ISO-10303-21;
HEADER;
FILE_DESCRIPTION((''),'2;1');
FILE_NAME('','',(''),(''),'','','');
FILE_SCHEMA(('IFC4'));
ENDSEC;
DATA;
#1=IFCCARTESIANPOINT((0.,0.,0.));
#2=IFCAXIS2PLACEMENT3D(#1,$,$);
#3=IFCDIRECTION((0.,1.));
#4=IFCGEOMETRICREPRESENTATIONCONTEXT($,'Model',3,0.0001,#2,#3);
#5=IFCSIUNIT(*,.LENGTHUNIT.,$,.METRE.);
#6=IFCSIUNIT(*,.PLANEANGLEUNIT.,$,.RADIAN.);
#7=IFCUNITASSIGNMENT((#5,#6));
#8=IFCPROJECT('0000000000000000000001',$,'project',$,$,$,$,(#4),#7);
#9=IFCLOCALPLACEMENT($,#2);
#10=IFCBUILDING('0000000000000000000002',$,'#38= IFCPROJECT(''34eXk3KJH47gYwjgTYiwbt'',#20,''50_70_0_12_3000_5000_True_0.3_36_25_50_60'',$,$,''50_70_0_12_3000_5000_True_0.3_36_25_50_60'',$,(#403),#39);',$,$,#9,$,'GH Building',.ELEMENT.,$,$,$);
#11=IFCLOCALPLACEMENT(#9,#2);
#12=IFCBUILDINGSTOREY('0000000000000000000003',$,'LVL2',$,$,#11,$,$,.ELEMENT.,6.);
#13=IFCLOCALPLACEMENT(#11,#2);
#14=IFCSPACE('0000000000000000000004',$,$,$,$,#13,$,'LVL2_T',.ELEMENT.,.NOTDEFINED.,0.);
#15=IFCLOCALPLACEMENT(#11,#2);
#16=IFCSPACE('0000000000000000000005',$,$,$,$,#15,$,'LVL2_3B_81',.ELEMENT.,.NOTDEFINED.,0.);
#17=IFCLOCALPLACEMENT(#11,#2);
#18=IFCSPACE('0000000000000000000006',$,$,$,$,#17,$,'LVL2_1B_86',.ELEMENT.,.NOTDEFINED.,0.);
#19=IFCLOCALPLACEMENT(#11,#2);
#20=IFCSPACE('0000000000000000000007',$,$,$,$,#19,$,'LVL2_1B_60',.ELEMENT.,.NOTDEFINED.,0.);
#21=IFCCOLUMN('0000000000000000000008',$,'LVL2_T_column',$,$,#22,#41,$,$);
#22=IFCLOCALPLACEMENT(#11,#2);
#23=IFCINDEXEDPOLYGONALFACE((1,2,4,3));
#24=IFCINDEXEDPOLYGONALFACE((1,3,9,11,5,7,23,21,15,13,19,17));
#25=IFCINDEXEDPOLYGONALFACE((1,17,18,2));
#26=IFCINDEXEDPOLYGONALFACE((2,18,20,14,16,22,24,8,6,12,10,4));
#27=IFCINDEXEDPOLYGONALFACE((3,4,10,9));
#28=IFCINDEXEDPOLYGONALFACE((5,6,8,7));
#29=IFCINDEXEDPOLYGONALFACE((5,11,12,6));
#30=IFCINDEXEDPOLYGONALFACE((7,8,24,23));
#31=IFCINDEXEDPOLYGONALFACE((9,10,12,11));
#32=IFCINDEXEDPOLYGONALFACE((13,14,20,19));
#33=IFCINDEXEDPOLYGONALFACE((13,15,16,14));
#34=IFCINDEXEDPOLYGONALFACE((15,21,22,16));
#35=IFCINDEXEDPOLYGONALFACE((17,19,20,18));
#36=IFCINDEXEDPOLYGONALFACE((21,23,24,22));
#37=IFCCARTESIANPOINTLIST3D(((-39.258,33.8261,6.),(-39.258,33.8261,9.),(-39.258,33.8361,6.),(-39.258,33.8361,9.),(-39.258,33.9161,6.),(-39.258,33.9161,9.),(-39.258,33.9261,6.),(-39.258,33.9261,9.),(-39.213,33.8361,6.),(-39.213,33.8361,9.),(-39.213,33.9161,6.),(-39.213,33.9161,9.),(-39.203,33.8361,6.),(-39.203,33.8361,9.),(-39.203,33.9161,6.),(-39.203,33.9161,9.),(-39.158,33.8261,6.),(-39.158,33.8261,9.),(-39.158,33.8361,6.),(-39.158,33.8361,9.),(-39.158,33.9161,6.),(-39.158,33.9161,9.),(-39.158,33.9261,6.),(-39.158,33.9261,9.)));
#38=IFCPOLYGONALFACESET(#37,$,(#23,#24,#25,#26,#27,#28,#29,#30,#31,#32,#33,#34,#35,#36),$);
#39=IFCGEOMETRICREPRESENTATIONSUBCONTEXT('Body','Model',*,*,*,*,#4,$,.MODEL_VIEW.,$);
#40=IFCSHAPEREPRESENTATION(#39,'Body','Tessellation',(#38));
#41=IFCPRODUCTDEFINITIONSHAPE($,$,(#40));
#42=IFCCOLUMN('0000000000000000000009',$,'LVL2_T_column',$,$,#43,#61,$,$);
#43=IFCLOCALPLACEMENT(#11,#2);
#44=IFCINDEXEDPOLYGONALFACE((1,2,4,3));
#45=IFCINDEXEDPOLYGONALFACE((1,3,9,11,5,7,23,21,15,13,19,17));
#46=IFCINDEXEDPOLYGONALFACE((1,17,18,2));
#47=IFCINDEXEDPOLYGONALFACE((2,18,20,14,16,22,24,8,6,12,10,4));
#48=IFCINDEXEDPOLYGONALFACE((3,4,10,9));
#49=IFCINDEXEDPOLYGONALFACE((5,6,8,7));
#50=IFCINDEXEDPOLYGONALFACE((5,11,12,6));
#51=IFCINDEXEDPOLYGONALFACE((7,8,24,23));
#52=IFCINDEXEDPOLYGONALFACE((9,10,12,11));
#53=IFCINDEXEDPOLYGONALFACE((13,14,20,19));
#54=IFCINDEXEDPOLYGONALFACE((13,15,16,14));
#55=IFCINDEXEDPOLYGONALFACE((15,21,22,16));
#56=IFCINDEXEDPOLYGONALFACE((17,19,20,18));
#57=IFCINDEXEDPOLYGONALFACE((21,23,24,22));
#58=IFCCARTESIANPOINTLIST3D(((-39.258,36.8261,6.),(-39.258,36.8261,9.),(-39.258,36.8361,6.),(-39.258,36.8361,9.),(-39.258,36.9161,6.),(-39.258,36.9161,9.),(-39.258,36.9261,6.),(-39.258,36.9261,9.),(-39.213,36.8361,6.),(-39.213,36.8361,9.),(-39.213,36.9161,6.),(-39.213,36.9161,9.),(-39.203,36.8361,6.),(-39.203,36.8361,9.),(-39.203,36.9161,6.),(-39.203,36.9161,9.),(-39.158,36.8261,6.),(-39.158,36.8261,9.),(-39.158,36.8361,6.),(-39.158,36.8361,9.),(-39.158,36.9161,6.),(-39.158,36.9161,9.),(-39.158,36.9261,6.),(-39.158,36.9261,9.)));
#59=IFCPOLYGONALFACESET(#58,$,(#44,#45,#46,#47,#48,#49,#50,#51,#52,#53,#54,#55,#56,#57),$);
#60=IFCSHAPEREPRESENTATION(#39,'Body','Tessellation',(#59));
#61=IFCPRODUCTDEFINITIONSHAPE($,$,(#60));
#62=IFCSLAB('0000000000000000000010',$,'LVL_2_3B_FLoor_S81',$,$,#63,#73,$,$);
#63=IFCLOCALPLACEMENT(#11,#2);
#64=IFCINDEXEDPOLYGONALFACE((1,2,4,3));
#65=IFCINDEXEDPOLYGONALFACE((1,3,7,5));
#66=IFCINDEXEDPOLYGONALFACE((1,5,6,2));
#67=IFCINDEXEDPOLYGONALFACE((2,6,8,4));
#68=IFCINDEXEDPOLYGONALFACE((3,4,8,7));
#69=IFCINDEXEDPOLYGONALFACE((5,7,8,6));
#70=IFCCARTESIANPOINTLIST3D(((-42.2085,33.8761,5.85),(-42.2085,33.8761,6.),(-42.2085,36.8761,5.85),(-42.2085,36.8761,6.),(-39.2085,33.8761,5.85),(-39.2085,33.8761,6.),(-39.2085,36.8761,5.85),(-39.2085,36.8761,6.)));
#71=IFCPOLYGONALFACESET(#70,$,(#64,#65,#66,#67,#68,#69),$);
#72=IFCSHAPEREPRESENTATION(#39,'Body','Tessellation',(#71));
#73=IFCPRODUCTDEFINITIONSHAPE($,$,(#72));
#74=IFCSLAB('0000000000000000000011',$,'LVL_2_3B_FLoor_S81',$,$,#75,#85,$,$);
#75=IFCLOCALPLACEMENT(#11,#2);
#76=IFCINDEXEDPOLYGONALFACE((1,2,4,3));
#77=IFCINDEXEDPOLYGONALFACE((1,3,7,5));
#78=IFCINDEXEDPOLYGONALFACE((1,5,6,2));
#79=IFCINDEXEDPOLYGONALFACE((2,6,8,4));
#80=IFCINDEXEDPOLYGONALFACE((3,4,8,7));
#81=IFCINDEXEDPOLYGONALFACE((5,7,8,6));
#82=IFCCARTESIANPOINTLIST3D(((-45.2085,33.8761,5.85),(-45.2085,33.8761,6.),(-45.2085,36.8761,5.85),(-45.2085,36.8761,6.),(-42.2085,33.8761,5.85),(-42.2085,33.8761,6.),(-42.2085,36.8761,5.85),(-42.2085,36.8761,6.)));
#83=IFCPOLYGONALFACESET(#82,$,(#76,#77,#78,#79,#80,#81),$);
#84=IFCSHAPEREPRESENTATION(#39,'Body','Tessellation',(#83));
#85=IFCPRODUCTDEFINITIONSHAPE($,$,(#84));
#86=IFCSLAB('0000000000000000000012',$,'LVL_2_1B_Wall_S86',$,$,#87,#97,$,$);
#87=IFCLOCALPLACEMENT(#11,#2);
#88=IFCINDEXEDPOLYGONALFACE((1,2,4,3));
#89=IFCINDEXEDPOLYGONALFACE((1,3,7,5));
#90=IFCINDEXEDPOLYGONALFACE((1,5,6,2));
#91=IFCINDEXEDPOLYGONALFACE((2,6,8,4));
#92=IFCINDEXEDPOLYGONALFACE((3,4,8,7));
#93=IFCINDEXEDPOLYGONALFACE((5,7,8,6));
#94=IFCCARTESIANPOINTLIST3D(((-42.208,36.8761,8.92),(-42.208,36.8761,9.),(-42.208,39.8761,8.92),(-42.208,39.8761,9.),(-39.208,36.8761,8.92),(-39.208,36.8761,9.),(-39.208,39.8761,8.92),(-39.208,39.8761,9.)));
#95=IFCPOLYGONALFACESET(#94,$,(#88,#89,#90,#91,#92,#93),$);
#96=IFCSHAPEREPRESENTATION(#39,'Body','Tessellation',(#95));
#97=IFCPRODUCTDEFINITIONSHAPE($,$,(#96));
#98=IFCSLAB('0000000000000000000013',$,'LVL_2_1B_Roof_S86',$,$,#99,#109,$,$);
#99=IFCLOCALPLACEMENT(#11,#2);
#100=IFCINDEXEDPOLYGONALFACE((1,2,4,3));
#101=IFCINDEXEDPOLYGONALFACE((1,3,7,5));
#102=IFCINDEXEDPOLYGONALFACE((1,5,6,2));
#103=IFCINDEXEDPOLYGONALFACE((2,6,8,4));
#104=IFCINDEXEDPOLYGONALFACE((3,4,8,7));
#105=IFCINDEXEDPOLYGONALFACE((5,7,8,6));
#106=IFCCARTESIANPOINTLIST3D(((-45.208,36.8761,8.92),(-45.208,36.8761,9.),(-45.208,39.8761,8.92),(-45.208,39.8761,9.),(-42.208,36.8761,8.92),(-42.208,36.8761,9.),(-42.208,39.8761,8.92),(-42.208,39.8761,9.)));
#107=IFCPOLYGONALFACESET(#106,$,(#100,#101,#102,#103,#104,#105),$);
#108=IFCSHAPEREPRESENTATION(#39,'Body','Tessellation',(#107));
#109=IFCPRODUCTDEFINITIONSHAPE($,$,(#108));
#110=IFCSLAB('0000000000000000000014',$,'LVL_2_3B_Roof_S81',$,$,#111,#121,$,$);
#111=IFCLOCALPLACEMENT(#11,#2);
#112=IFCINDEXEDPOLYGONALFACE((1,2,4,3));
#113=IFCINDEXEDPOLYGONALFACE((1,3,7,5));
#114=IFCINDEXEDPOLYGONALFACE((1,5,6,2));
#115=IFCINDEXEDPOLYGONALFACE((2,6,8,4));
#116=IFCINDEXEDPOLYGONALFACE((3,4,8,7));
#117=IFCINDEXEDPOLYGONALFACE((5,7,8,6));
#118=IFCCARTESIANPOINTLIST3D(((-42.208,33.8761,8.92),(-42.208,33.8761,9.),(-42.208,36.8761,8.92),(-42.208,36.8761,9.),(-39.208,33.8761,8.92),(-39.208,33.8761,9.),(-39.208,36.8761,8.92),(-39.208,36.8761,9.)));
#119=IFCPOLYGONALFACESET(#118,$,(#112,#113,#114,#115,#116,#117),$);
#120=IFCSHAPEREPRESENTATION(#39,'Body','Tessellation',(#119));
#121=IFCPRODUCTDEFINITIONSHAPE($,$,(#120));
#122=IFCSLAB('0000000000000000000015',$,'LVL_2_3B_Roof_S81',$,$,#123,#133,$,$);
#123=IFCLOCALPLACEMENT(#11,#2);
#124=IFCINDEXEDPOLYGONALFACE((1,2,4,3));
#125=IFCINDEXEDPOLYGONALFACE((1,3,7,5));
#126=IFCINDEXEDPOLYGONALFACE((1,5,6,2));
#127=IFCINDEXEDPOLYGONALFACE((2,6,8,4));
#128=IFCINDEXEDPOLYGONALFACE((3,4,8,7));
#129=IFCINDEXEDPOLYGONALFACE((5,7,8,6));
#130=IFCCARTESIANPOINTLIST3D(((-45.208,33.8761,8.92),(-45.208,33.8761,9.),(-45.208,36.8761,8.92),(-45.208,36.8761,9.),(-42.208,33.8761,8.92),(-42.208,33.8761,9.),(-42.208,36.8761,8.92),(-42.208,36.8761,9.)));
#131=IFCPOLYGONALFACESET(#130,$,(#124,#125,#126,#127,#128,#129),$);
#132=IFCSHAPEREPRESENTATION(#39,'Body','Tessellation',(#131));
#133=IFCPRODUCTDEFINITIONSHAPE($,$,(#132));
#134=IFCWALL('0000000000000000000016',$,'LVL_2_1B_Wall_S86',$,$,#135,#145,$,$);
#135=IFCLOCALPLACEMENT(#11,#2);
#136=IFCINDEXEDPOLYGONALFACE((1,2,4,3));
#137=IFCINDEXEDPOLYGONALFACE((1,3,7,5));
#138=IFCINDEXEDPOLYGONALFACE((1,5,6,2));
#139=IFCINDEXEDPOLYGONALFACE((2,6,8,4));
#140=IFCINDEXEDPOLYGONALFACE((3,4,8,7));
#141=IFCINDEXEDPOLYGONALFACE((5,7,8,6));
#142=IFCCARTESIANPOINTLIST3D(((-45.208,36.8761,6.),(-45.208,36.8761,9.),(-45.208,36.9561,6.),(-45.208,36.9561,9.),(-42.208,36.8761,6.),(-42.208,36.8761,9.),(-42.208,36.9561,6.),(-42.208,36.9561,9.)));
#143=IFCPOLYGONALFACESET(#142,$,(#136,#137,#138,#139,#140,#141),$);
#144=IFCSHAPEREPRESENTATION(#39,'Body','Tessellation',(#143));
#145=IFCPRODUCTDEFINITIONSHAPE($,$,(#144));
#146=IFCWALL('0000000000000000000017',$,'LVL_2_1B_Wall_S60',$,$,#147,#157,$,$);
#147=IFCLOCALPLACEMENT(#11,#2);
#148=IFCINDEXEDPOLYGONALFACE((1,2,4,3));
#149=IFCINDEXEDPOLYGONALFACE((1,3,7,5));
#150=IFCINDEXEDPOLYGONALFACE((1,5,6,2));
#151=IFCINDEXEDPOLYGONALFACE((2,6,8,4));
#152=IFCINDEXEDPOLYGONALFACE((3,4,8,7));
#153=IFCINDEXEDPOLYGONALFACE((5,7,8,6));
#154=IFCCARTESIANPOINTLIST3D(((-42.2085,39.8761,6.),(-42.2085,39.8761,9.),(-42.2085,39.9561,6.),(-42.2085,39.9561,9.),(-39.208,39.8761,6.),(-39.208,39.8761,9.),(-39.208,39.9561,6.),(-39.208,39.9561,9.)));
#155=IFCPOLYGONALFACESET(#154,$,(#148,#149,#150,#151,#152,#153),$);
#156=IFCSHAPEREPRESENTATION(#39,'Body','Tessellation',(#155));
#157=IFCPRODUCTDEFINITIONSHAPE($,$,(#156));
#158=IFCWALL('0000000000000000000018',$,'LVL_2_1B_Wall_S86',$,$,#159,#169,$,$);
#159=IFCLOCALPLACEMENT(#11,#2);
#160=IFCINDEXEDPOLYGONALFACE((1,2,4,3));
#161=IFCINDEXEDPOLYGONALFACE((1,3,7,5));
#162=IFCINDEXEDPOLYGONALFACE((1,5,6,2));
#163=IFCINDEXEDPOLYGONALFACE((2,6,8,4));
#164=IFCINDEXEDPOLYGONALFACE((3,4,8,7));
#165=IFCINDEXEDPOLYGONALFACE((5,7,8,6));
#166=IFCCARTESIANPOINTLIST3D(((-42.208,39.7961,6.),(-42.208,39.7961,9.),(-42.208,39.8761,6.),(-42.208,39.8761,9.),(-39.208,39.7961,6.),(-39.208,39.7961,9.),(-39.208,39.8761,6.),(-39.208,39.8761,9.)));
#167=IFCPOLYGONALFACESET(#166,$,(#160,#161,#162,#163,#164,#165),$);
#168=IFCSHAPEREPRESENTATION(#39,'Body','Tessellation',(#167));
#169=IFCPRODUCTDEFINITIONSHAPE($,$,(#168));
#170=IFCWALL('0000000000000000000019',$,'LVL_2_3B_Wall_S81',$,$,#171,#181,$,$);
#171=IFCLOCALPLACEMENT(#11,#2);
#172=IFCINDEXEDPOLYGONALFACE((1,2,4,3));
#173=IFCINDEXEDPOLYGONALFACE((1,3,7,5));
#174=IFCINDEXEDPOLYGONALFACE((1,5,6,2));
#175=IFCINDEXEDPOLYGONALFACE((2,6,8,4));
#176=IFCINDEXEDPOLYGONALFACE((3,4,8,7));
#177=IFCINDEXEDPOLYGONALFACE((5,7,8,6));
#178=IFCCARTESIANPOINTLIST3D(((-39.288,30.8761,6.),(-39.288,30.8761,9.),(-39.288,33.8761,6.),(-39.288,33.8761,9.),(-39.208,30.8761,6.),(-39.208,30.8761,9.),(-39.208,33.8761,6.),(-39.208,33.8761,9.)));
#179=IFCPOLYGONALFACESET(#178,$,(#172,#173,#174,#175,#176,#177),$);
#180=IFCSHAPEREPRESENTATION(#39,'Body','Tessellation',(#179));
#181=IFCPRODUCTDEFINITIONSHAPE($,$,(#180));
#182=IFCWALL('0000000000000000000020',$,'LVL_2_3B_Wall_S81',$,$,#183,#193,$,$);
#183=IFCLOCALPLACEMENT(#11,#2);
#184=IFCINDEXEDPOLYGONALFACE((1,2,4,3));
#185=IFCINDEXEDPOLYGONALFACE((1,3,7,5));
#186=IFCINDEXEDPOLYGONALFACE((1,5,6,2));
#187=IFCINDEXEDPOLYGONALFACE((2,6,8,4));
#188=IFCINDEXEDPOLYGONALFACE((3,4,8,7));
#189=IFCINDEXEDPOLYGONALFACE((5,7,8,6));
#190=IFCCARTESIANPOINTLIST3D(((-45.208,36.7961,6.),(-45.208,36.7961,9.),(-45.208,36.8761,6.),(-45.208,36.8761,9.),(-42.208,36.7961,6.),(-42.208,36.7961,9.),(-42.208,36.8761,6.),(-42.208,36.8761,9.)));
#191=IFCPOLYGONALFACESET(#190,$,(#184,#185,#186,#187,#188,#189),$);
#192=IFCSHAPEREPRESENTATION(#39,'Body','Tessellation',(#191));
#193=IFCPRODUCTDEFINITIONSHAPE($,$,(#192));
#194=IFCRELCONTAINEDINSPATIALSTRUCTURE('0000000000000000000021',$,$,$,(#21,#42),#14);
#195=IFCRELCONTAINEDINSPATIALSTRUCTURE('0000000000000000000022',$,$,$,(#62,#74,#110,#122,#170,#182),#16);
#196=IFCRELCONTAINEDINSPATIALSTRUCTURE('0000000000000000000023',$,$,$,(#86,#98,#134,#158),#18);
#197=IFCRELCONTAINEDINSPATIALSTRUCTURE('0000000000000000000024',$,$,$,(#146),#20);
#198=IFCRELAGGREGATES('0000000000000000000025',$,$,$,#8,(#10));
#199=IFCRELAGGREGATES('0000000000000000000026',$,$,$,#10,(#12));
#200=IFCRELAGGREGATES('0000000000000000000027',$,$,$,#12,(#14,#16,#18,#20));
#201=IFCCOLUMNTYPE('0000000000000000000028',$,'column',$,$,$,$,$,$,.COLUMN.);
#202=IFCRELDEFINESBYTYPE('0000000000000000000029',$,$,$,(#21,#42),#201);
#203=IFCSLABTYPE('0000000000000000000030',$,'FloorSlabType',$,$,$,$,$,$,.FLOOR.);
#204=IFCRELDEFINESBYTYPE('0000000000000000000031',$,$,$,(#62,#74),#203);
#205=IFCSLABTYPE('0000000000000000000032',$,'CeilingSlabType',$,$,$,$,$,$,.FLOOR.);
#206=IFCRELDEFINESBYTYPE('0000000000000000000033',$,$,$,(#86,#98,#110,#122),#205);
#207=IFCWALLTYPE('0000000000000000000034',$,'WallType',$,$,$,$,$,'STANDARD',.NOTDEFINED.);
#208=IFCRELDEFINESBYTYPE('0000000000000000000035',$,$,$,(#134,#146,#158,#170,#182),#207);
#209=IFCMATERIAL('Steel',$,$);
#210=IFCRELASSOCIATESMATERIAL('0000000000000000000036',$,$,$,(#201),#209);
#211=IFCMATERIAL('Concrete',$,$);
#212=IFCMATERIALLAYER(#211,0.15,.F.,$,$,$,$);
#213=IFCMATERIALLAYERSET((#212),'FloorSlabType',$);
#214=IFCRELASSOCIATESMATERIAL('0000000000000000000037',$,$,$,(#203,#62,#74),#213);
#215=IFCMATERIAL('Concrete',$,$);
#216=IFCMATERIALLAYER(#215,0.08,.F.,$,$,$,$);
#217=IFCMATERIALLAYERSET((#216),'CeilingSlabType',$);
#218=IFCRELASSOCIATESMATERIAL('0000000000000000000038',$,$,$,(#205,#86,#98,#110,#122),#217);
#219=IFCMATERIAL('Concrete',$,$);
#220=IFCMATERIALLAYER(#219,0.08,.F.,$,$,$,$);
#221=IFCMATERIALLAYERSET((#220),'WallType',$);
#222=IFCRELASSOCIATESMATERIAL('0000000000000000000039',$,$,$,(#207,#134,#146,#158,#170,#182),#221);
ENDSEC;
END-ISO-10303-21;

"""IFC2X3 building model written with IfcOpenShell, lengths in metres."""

from ifc_helpers import new_model, si_unit, direction, frame, frame_2d, origin, origin_2d, place, context, subcontext, project, spatial, rectangle, i_section, extrude, material, layer, layer_set, layer_usage, type_object, element, save


model = new_model("IFC2X3")

# Units and contexts
model_context = context("Model", 3, precision=0.0001, world=origin(), true_north=direction((0.0, 1.0)))
body_context = subcontext(model_context, "Body", "Model", "MODEL_VIEW")
ifc_project = project(units=[si_unit("LENGTHUNIT", "METRE"), si_unit("PLANEANGLEUNIT", "RADIAN")], contexts=[model_context])

# Building, storey, space
building_placement = place(None, origin())
building = spatial("IfcBuilding", under=ifc_project, at=building_placement, Name="#38= IFCPROJECT('34eXk3KJH47gYwjgTYiwbt',#20,'50_70_0_12_3000_5000_True_0.3_36_25_50_60',$,$,'50_70_0_12_3000_5000_True_0.3_36_25_50_60',$,(#403),#39);", LongName="GH Building", CompositionType="ELEMENT")
storey_placement = place(building_placement, origin())
storey = spatial("IfcBuildingStorey", under=building, at=storey_placement, Name="LVL2", CompositionType="ELEMENT", Elevation=6.0)
space_1_placement = place(storey_placement, origin())
space_1 = spatial("IfcSpace", under=storey, at=space_1_placement, LongName="LVL2_T", CompositionType="ELEMENT", InteriorOrExteriorSpace="NOTDEFINED", ElevationWithFlooring=0.0)

# Columns
ifc_material_1 = material(Name="Steel")
column_type = type_object("IfcColumnType", Name="column", PredefinedType="COLUMN", material=ifc_material_1)
for number, where, name in (
    (1, (-39.208, 33.8761, 6.0), "LVL2_T_column"),
    (2, (-39.208, 36.8761, 6.0), "LVL2_T_column"),
):
    element("IfcColumn", number, at=place(space_1_placement, frame(where)), inside=space_1, type_object=column_type, Name=name, context=body_context, shape_type="SweptSolid", body=[
        extrude(i_section(OverallWidth=0.1, OverallDepth=0.1, WebThickness=0.01, FlangeThickness=0.01, at=origin_2d()), origin(), (0.0, 0.0, 1.0), 3.0),
    ])

# Shared definitions
space_2_placement = place(storey_placement, origin())
space_2 = spatial("IfcSpace", under=storey, at=space_2_placement, LongName="LVL2_3B_81", CompositionType="ELEMENT", InteriorOrExteriorSpace="NOTDEFINED", ElevationWithFlooring=0.0)

# Slabs
ifc_material_2 = material(Name="Concrete")
ifc_layer_1 = layer(ifc_material_2, 0.15, ventilated=False)
ifc_layer_set_1 = layer_set([ifc_layer_1], Name="FloorSlabType")
ifc_layer_usage_1 = layer_usage(ifc_layer_set_1, "AXIS3", "NEGATIVE", -0.15)
slab_type_1 = type_object("IfcSlabType", Name="FloorSlabType", PredefinedType="FLOOR", material=ifc_layer_set_1)
slab_1_placement = place(space_2_placement, frame((-42.2085, 36.8761, 5.85), z_axis=(0.0, 0.0, 1.0), x_axis=(0.0, -1.0, 0.0)))
element("IfcSlab", 3, at=slab_1_placement, inside=space_2, type_object=slab_type_1, material=ifc_layer_usage_1, Name="LVL_2_3B_FLoor_S81", context=body_context, shape_type="SweptSolid", body=[
    extrude(rectangle(XDim=3.0, YDim=3.0, at=frame_2d((1.5, 1.5))), origin(), (0.0, 0.0, 1.0), 0.15),
])
ifc_layer_usage_2 = layer_usage(ifc_layer_set_1, "AXIS3", "NEGATIVE", -0.15)
slab_2_placement = place(space_2_placement, frame((-45.2085, 36.8761, 5.85), z_axis=(0.0, 0.0, 1.0), x_axis=(0.0, -1.0, 0.0)))
element("IfcSlab", 4, at=slab_2_placement, inside=space_2, type_object=slab_type_1, material=ifc_layer_usage_2, Name="LVL_2_3B_FLoor_S81", context=body_context, shape_type="SweptSolid", body=[
    extrude(rectangle(XDim=3.0, YDim=3.0, at=frame_2d((1.5, 1.5))), origin(), (0.0, 0.0, 1.0), 0.15),
])

# Shared definitions
space_3_placement = place(storey_placement, origin())
space_3 = spatial("IfcSpace", under=storey, at=space_3_placement, LongName="LVL2_1B_86", CompositionType="ELEMENT", InteriorOrExteriorSpace="NOTDEFINED", ElevationWithFlooring=0.0)

# Slabs
ifc_material_3 = material(Name="Concrete")
ifc_layer_2 = layer(ifc_material_3, 0.08, ventilated=False)
ifc_layer_set_2 = layer_set([ifc_layer_2], Name="CeilingSlabType")
ifc_layer_usage_3 = layer_usage(ifc_layer_set_2, "AXIS3", "NEGATIVE", -0.08)
slab_type_2 = type_object("IfcSlabType", Name="CeilingSlabType", PredefinedType="FLOOR", material=ifc_layer_set_2)
slab_3_placement = place(space_3_placement, frame((-39.208, 39.8761, 8.92), z_axis=(0.0, 0.0, 1.0), x_axis=(-1.0, 0.0, 0.0)))
element("IfcSlab", 5, at=slab_3_placement, inside=space_3, type_object=slab_type_2, material=ifc_layer_usage_3, Name="LVL_2_1B_Wall_S86", context=body_context, shape_type="SweptSolid", body=[
    extrude(rectangle(XDim=3.0, YDim=3.0, at=frame_2d((1.5, 1.5))), origin(), (0.0, 0.0, 1.0), 0.08),
])
ifc_layer_usage_4 = layer_usage(ifc_layer_set_2, "AXIS3", "NEGATIVE", -0.08)
slab_4_placement = place(space_3_placement, frame((-42.208, 39.8761, 8.92), z_axis=(0.0, 0.0, 1.0), x_axis=(-1.0, 0.0, 0.0)))
element("IfcSlab", 6, at=slab_4_placement, inside=space_3, type_object=slab_type_2, material=ifc_layer_usage_4, Name="LVL_2_1B_Roof_S86", context=body_context, shape_type="SweptSolid", body=[
    extrude(rectangle(XDim=3.0, YDim=3.0, at=frame_2d((1.5, 1.5))), origin(), (0.0, 0.0, 1.0), 0.08),
])
ifc_layer_usage_5 = layer_usage(ifc_layer_set_2, "AXIS3", "NEGATIVE", -0.08)
slab_5_placement = place(space_2_placement, frame((-42.208, 36.8761, 8.92), z_axis=(0.0, 0.0, 1.0), x_axis=(0.0, -1.0, 0.0)))
element("IfcSlab", 7, at=slab_5_placement, inside=space_2, type_object=slab_type_2, material=ifc_layer_usage_5, Name="LVL_2_3B_Roof_S81", context=body_context, shape_type="SweptSolid", body=[
    extrude(rectangle(XDim=3.0, YDim=3.0, at=frame_2d((1.5, 1.5))), origin(), (0.0, 0.0, 1.0), 0.08),
])
ifc_layer_usage_6 = layer_usage(ifc_layer_set_2, "AXIS3", "NEGATIVE", -0.08)
slab_6_placement = place(space_2_placement, frame((-45.208, 36.8761, 8.92), z_axis=(0.0, 0.0, 1.0), x_axis=(0.0, -1.0, 0.0)))
element("IfcSlab", 8, at=slab_6_placement, inside=space_2, type_object=slab_type_2, material=ifc_layer_usage_6, Name="LVL_2_3B_Roof_S81", context=body_context, shape_type="SweptSolid", body=[
    extrude(rectangle(XDim=3.0, YDim=3.0, at=frame_2d((1.5, 1.5))), origin(), (0.0, 0.0, 1.0), 0.08),
])

# Shared definitions
ifc_material_4 = material(Name="Concrete")
ifc_layer_3 = layer(ifc_material_4, 0.08, ventilated=False)
ifc_layer_set_3 = layer_set([ifc_layer_3], Name="WallType")
wall_type = type_object("IfcWallType", Name="WallType", ElementType="STANDARD", PredefinedType="NOTDEFINED", material=ifc_layer_set_3)

# Shared definitions
space_4_placement = place(storey_placement, origin())
space_4 = spatial("IfcSpace", under=storey, at=space_4_placement, LongName="LVL2_1B_60", CompositionType="ELEMENT", InteriorOrExteriorSpace="NOTDEFINED", ElevationWithFlooring=0.0)

# Walls
ifc_layer_usage_7 = layer_usage(ifc_layer_set_3, "AXIS2", "NEGATIVE", 0.0)
wall_1_placement = place(space_3_placement, frame((-42.208, 36.8761, 6.0), z_axis=(0.0, 0.0, 1.0), x_axis=(-1.0, 0.0, 0.0)))
element("IfcWall", 9, at=wall_1_placement, inside=space_3, type_object=wall_type, material=ifc_layer_usage_7, Name="LVL_2_1B_Wall_S86", context=body_context, shape_type="SweptSolid", body=[
    extrude(rectangle(XDim=3.0, YDim=0.08, at=frame_2d((1.5, -0.04))), origin(), (0.0, 0.0, 1.0), 3.0),
])
ifc_layer_usage_8 = layer_usage(ifc_layer_set_3, "AXIS2", "NEGATIVE", 0.0)
wall_2_placement = place(space_4_placement, frame((-39.208, 39.8761, 6.0), z_axis=(0.0, 0.0, 1.0), x_axis=(-1.0, 0.0, 0.0)))
element("IfcWall", 10, at=wall_2_placement, inside=space_4, type_object=wall_type, material=ifc_layer_usage_8, Name="LVL_2_1B_Wall_S60", context=body_context, shape_type="SweptSolid", body=[
    extrude(rectangle(XDim=3.0005, YDim=0.08, at=frame_2d((1.5003, -0.04))), origin(), (0.0, 0.0, 1.0), 3.0),
])
ifc_layer_usage_9 = layer_usage(ifc_layer_set_3, "AXIS2", "NEGATIVE", 0.0)
wall_3_placement = place(space_3_placement, frame((-42.208, 39.8761, 6.0)))
element("IfcWall", 11, at=wall_3_placement, inside=space_3, type_object=wall_type, material=ifc_layer_usage_9, Name="LVL_2_1B_Wall_S86", context=body_context, shape_type="SweptSolid", body=[
    extrude(rectangle(XDim=3.0, YDim=0.08, at=frame_2d((1.5, -0.04))), origin(), (0.0, 0.0, 1.0), 3.0),
])

# Walls
ifc_layer_usage_10 = layer_usage(ifc_layer_set_3, "AXIS2", "NEGATIVE", 0.0)
wall_4_placement = place(space_2_placement, frame((-39.208, 33.8761, 6.0), z_axis=(0.0, 0.0, 1.0), x_axis=(0.0, -1.0, 0.0)))
element("IfcWall", 12, at=wall_4_placement, inside=space_2, type_object=wall_type, material=ifc_layer_usage_10, Name="LVL_2_3B_Wall_S81", context=body_context, shape_type="SweptSolid", body=[
    extrude(rectangle(XDim=3.0, YDim=0.08, at=frame_2d((1.5, -0.04))), origin(), (0.0, 0.0, 1.0), 3.0),
])
ifc_layer_usage_11 = layer_usage(ifc_layer_set_3, "AXIS2", "NEGATIVE", 0.0)
wall_5_placement = place(space_2_placement, frame((-45.208, 36.8761, 6.0)))
element("IfcWall", 13, at=wall_5_placement, inside=space_2, type_object=wall_type, material=ifc_layer_usage_11, Name="LVL_2_3B_Wall_S81", context=body_context, shape_type="SweptSolid", body=[
    extrude(rectangle(XDim=3.0, YDim=0.08, at=frame_2d((1.5, -0.04))), origin(), (0.0, 0.0, 1.0), 3.0),
])

save(model, "model.ifc")
